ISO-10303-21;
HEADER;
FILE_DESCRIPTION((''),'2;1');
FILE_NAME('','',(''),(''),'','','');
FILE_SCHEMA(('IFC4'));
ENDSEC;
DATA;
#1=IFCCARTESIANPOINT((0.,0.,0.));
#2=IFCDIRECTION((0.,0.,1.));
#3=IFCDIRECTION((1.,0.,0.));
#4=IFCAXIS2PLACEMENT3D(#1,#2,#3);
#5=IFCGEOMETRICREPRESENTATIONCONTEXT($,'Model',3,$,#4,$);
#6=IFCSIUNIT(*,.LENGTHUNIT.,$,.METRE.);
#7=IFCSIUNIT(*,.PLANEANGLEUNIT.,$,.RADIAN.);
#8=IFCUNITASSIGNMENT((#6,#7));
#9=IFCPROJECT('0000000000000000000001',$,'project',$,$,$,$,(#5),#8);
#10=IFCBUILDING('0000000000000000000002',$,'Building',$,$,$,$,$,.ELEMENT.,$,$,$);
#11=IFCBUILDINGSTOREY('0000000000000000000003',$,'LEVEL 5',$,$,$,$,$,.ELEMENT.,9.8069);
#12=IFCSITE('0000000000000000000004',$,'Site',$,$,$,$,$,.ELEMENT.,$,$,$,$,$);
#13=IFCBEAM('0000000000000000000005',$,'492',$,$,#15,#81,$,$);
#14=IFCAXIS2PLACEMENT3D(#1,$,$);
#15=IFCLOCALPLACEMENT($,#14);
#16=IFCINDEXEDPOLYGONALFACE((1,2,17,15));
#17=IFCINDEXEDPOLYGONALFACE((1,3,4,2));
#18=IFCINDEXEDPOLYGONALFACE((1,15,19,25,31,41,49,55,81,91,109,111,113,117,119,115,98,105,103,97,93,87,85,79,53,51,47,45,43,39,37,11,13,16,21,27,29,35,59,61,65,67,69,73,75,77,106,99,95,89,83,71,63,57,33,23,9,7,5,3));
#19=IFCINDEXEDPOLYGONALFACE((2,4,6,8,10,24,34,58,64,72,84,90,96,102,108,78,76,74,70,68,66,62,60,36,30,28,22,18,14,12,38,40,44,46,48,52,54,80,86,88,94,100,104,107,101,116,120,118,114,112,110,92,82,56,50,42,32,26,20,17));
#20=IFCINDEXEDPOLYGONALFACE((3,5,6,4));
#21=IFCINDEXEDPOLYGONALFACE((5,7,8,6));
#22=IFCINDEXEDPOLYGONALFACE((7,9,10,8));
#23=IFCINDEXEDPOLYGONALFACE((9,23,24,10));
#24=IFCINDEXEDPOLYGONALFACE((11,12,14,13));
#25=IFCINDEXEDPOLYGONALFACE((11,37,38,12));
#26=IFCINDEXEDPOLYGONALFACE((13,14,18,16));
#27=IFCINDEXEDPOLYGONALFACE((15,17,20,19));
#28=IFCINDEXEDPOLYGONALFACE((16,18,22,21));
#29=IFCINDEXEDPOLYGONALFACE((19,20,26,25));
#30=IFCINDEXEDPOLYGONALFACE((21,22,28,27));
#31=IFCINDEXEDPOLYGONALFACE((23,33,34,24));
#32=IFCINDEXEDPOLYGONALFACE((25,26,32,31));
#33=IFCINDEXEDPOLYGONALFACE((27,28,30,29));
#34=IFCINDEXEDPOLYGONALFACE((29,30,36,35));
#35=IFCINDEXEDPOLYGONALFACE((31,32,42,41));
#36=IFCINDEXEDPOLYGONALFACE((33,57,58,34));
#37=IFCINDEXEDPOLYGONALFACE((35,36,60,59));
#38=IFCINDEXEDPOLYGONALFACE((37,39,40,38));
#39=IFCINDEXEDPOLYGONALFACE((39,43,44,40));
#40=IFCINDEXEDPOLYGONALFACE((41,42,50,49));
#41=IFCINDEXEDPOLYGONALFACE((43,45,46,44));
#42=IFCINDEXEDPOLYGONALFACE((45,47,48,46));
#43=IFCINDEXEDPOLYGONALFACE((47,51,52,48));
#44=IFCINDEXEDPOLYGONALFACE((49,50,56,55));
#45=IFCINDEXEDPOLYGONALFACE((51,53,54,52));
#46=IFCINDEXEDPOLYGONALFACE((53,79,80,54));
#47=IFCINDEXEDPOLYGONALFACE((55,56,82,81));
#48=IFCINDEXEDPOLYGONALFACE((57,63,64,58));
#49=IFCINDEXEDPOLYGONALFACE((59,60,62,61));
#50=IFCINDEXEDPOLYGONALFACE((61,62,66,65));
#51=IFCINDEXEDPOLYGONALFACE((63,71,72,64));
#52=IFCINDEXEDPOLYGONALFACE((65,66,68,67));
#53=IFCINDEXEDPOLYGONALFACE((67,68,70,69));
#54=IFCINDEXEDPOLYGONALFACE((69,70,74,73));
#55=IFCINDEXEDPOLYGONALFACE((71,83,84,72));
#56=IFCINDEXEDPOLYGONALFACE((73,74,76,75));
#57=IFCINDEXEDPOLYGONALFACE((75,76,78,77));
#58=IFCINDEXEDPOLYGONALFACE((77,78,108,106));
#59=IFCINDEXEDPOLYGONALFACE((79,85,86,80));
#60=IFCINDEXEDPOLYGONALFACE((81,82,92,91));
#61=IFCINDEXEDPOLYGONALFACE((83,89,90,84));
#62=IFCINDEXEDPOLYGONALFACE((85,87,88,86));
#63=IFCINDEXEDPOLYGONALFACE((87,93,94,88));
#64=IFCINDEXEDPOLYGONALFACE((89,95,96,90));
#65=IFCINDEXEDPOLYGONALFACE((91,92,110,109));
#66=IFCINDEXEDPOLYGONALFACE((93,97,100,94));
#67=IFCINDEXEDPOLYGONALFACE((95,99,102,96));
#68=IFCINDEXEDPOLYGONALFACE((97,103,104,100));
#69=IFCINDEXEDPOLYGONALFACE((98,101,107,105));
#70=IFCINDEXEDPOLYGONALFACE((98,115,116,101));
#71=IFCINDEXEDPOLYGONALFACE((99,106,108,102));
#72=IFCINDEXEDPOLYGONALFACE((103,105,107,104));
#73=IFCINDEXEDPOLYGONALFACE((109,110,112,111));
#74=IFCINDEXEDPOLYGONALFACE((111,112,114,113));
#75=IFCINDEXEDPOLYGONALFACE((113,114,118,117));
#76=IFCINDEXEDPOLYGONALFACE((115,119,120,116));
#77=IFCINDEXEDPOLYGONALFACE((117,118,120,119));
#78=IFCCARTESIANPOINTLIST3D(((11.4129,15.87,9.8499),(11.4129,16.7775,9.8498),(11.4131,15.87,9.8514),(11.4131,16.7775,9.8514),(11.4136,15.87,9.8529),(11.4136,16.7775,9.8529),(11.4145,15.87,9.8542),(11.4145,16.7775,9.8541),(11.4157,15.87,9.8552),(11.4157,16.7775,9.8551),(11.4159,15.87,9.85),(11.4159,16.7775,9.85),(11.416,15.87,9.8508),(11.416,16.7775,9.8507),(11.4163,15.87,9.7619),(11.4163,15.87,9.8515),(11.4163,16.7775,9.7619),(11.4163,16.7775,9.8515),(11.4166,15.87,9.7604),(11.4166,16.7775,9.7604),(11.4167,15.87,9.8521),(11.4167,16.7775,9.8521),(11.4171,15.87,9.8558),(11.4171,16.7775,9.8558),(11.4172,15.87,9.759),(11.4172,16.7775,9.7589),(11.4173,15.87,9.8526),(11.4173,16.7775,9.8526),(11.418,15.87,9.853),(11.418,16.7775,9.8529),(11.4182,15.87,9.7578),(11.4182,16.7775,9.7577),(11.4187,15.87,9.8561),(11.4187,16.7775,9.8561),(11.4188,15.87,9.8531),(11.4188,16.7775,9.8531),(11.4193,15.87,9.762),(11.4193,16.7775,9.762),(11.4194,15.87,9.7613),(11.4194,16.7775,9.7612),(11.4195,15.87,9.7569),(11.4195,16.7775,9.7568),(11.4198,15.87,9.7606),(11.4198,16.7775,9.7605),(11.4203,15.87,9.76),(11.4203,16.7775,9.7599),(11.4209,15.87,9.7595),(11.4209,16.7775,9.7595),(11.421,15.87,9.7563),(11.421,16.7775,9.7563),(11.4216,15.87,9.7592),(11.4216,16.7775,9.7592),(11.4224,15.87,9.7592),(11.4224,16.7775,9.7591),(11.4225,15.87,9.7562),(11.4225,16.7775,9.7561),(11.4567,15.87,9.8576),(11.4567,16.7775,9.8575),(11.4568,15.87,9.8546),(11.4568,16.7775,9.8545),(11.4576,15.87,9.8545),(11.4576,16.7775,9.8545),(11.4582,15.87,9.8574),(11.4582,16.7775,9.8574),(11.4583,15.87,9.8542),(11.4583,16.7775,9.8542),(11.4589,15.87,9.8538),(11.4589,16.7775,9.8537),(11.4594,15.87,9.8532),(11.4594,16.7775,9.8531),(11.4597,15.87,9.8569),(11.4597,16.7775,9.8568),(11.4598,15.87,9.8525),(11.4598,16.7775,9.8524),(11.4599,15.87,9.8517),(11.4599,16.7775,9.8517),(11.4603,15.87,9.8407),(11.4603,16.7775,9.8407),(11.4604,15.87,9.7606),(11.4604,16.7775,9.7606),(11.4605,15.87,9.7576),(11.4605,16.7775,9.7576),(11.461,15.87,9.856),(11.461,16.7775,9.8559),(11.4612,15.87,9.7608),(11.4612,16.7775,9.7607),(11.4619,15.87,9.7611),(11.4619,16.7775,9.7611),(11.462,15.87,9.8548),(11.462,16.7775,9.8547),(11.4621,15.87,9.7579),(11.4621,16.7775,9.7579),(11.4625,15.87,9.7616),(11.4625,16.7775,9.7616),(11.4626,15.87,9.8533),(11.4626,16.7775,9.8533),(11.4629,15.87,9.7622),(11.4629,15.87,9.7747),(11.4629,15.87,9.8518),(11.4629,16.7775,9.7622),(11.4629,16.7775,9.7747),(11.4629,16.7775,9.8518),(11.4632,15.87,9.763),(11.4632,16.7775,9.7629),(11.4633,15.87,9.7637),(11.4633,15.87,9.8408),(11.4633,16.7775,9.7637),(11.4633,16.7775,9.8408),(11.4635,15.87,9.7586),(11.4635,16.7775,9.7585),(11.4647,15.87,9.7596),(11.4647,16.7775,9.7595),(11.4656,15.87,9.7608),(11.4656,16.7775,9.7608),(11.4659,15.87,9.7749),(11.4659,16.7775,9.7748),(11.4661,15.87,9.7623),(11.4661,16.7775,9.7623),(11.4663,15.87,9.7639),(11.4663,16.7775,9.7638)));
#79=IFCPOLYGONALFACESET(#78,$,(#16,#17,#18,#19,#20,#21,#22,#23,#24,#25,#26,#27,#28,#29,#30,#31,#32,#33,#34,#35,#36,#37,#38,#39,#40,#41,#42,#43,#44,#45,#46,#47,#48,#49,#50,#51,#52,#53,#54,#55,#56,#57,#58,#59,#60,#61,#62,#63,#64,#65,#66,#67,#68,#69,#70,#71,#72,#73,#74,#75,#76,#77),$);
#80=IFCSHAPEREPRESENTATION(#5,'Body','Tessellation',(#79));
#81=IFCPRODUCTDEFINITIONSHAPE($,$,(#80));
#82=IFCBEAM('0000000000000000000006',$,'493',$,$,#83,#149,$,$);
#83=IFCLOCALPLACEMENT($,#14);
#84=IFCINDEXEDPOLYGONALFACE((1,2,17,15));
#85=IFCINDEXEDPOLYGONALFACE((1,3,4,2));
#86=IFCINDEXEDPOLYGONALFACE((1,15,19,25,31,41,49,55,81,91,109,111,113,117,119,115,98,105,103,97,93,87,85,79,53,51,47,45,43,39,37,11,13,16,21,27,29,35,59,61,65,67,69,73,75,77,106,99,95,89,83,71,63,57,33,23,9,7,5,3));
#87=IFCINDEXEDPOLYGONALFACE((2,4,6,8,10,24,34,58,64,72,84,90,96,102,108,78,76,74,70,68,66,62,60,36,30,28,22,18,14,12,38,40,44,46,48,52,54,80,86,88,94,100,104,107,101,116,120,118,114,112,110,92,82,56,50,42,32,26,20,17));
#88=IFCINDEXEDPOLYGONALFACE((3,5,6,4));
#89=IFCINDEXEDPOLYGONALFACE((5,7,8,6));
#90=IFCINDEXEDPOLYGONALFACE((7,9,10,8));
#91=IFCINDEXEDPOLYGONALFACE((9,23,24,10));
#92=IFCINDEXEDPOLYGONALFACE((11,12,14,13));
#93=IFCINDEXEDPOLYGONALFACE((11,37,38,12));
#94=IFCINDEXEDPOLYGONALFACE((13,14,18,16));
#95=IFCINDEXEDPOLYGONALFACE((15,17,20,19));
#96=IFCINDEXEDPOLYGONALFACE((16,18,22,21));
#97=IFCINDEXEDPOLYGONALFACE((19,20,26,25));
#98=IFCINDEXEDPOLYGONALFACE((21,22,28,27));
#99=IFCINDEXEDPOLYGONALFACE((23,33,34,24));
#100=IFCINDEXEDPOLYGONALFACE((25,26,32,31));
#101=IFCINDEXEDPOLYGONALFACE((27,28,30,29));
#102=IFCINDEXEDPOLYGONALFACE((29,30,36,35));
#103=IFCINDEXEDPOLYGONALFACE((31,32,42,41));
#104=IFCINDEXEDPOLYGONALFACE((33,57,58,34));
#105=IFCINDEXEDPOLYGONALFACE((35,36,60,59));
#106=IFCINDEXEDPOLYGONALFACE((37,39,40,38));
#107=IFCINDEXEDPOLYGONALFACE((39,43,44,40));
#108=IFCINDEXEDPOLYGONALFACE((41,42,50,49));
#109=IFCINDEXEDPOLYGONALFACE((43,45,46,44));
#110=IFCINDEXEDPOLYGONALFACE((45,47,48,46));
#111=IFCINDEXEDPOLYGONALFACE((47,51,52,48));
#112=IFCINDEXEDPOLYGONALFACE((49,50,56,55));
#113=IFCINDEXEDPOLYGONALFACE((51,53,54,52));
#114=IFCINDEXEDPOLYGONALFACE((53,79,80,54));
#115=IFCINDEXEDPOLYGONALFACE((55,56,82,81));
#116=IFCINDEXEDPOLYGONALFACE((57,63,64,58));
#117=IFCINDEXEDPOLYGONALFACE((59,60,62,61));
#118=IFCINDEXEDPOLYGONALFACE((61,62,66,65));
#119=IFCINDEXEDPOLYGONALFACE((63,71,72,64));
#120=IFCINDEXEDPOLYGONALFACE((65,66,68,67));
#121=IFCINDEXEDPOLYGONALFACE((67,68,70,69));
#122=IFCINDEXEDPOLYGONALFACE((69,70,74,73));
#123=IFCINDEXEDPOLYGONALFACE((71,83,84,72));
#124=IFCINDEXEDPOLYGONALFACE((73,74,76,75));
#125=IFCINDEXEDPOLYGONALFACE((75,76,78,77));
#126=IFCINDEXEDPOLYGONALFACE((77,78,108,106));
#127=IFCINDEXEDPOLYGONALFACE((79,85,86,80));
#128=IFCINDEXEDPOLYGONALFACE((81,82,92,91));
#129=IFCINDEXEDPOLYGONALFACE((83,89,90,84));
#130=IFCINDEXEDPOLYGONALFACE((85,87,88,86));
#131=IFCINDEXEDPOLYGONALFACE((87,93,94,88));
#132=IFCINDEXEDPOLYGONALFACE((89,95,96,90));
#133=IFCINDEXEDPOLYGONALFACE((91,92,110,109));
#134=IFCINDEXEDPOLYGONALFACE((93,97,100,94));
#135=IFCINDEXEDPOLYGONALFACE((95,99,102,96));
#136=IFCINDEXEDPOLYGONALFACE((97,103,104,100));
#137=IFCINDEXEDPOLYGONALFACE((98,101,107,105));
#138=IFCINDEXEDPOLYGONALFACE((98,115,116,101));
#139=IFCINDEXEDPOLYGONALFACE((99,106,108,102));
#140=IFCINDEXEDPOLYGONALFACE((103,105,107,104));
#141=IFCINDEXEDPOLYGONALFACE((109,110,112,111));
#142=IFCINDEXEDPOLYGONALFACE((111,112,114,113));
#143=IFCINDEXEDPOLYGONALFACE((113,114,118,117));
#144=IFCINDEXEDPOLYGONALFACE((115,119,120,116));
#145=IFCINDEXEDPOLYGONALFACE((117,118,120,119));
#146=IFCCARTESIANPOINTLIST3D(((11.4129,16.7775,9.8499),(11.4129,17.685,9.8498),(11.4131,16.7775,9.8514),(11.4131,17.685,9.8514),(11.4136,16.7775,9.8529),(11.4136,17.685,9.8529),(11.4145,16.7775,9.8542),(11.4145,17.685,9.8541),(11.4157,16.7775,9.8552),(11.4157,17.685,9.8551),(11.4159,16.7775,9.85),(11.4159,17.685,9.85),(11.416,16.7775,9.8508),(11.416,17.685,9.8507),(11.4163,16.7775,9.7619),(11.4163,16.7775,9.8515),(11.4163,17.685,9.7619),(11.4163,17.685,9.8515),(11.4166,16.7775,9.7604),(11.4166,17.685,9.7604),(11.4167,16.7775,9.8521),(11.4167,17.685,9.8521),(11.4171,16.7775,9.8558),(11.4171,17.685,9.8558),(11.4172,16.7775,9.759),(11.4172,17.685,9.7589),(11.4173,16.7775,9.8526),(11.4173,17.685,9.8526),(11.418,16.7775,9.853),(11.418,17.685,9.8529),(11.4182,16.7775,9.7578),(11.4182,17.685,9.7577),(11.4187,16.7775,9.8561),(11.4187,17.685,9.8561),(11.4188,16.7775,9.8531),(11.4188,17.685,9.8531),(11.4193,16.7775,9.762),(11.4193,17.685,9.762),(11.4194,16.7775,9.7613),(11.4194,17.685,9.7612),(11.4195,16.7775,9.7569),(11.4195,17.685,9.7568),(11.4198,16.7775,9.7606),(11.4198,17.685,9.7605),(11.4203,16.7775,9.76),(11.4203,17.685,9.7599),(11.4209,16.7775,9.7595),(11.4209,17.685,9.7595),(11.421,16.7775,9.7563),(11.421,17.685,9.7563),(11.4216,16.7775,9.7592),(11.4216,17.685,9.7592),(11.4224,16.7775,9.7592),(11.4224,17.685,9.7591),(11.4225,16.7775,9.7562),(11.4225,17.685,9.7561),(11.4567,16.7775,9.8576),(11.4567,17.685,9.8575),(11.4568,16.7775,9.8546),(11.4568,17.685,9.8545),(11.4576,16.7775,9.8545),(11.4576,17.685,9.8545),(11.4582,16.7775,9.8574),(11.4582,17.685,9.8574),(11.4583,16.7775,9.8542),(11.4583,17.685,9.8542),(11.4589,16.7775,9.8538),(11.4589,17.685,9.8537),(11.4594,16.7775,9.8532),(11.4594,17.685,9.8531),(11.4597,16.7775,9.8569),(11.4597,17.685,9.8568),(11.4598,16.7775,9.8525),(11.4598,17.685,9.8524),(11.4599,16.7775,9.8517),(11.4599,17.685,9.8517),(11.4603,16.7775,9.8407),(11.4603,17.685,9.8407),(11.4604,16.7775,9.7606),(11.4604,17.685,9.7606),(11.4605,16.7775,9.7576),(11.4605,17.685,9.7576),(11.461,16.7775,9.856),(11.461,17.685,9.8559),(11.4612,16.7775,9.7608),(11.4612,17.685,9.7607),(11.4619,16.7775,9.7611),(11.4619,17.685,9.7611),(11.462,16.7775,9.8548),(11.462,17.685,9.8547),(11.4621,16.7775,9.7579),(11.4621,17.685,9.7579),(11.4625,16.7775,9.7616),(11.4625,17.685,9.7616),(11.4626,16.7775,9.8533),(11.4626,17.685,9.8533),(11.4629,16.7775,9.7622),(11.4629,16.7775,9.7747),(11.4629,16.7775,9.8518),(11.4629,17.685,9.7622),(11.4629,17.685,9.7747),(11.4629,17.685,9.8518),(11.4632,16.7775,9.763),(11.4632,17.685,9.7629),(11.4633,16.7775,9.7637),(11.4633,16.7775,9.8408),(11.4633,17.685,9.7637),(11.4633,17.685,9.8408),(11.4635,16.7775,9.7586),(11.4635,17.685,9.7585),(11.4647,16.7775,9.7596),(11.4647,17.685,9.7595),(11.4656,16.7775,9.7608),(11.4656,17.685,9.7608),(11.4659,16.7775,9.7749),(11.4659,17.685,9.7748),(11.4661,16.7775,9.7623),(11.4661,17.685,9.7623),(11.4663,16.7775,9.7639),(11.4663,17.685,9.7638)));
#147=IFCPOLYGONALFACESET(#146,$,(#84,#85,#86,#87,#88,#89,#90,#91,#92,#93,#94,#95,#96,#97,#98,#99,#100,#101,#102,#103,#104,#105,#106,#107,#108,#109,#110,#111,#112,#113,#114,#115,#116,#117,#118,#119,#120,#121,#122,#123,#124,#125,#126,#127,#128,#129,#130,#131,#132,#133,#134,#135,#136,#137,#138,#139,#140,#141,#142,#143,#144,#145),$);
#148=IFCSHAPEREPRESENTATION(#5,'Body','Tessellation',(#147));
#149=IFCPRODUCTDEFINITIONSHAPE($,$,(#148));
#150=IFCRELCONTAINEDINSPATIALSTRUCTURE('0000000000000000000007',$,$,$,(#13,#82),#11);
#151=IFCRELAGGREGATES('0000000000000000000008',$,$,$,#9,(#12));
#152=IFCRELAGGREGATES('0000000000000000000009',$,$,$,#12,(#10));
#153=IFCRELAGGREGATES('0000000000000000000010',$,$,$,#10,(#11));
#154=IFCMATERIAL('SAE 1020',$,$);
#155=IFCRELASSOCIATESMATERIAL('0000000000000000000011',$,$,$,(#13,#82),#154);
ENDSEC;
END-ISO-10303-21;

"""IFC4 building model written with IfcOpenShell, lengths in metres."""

from ifc_helpers import new_model, si_unit, frame, origin_with_axes, origin_2d_with_axis, place, context, project, spatial, c_section, extrude, material, material_profile, profile_set, profile_usage, element, save


model = new_model("IFC4")

# Units and contexts
model_context = context("Model", 3, world=origin_with_axes())
ifc_project = project(units=[si_unit("LENGTHUNIT", "METRE"), si_unit("PLANEANGLEUNIT", "RADIAN")], contexts=[model_context])

# Site, building, storey
site = spatial("IfcSite", under=ifc_project, Name="Site", CompositionType="ELEMENT")
building = spatial("IfcBuilding", under=site, Name="Building", CompositionType="ELEMENT")
storey = spatial("IfcBuildingStorey", under=building, Name="LEVEL 5", CompositionType="ELEMENT", Elevation=9.8069)

# Beams
ifc_material = material(Name="SAE 1020")
ifc_material_profile_1 = material_profile(ifc_material, c_section(Depth=0.1, Width=0.05, WallThickness=0.003, Girth=0.017, InternalFilletRadius=0.003, at=origin_2d_with_axis()))
ifc_profile_set_1 = profile_set([ifc_material_profile_1])
ifc_profile_usage_1 = profile_usage(ifc_profile_set_1, cardinal=10)
beam_1_placement = place(None, frame((11.4396, 15.87, 9.8069), z_axis=(0.0, 1.0, -0.00003), x_axis=(0.999256, 0.000001, 0.038562)))
element("IfcBeam", 1, at=beam_1_placement, inside=storey, material=ifc_profile_usage_1, Name="492", context=model_context, shape_type="SweptSolid", body=[
    extrude(c_section(Depth=0.1, Width=0.05, WallThickness=0.003, Girth=0.017, InternalFilletRadius=0.003, at=origin_2d_with_axis()), origin_with_axes(), (0.0, 0.0, 1.0), 0.9075),
])
ifc_material_profile_2 = material_profile(ifc_material, c_section(Depth=0.1, Width=0.05, WallThickness=0.003, Girth=0.017, InternalFilletRadius=0.003, at=origin_2d_with_axis()))
ifc_profile_set_2 = profile_set([ifc_material_profile_2])
ifc_profile_usage_2 = profile_usage(ifc_profile_set_2, cardinal=10)
beam_2_placement = place(None, frame((11.4396, 16.7775, 9.8069), z_axis=(0.0, 1.0, -0.00003), x_axis=(0.999256, 0.000001, 0.038562)))
element("IfcBeam", 2, at=beam_2_placement, inside=storey, material=ifc_profile_usage_2, Name="493", context=model_context, shape_type="SweptSolid", body=[
    extrude(c_section(Depth=0.1, Width=0.05, WallThickness=0.003, Girth=0.017, InternalFilletRadius=0.003, at=origin_2d_with_axis()), origin_with_axes(), (0.0, 0.0, 1.0), 0.9075),
])

save(model, "model.ifc")
